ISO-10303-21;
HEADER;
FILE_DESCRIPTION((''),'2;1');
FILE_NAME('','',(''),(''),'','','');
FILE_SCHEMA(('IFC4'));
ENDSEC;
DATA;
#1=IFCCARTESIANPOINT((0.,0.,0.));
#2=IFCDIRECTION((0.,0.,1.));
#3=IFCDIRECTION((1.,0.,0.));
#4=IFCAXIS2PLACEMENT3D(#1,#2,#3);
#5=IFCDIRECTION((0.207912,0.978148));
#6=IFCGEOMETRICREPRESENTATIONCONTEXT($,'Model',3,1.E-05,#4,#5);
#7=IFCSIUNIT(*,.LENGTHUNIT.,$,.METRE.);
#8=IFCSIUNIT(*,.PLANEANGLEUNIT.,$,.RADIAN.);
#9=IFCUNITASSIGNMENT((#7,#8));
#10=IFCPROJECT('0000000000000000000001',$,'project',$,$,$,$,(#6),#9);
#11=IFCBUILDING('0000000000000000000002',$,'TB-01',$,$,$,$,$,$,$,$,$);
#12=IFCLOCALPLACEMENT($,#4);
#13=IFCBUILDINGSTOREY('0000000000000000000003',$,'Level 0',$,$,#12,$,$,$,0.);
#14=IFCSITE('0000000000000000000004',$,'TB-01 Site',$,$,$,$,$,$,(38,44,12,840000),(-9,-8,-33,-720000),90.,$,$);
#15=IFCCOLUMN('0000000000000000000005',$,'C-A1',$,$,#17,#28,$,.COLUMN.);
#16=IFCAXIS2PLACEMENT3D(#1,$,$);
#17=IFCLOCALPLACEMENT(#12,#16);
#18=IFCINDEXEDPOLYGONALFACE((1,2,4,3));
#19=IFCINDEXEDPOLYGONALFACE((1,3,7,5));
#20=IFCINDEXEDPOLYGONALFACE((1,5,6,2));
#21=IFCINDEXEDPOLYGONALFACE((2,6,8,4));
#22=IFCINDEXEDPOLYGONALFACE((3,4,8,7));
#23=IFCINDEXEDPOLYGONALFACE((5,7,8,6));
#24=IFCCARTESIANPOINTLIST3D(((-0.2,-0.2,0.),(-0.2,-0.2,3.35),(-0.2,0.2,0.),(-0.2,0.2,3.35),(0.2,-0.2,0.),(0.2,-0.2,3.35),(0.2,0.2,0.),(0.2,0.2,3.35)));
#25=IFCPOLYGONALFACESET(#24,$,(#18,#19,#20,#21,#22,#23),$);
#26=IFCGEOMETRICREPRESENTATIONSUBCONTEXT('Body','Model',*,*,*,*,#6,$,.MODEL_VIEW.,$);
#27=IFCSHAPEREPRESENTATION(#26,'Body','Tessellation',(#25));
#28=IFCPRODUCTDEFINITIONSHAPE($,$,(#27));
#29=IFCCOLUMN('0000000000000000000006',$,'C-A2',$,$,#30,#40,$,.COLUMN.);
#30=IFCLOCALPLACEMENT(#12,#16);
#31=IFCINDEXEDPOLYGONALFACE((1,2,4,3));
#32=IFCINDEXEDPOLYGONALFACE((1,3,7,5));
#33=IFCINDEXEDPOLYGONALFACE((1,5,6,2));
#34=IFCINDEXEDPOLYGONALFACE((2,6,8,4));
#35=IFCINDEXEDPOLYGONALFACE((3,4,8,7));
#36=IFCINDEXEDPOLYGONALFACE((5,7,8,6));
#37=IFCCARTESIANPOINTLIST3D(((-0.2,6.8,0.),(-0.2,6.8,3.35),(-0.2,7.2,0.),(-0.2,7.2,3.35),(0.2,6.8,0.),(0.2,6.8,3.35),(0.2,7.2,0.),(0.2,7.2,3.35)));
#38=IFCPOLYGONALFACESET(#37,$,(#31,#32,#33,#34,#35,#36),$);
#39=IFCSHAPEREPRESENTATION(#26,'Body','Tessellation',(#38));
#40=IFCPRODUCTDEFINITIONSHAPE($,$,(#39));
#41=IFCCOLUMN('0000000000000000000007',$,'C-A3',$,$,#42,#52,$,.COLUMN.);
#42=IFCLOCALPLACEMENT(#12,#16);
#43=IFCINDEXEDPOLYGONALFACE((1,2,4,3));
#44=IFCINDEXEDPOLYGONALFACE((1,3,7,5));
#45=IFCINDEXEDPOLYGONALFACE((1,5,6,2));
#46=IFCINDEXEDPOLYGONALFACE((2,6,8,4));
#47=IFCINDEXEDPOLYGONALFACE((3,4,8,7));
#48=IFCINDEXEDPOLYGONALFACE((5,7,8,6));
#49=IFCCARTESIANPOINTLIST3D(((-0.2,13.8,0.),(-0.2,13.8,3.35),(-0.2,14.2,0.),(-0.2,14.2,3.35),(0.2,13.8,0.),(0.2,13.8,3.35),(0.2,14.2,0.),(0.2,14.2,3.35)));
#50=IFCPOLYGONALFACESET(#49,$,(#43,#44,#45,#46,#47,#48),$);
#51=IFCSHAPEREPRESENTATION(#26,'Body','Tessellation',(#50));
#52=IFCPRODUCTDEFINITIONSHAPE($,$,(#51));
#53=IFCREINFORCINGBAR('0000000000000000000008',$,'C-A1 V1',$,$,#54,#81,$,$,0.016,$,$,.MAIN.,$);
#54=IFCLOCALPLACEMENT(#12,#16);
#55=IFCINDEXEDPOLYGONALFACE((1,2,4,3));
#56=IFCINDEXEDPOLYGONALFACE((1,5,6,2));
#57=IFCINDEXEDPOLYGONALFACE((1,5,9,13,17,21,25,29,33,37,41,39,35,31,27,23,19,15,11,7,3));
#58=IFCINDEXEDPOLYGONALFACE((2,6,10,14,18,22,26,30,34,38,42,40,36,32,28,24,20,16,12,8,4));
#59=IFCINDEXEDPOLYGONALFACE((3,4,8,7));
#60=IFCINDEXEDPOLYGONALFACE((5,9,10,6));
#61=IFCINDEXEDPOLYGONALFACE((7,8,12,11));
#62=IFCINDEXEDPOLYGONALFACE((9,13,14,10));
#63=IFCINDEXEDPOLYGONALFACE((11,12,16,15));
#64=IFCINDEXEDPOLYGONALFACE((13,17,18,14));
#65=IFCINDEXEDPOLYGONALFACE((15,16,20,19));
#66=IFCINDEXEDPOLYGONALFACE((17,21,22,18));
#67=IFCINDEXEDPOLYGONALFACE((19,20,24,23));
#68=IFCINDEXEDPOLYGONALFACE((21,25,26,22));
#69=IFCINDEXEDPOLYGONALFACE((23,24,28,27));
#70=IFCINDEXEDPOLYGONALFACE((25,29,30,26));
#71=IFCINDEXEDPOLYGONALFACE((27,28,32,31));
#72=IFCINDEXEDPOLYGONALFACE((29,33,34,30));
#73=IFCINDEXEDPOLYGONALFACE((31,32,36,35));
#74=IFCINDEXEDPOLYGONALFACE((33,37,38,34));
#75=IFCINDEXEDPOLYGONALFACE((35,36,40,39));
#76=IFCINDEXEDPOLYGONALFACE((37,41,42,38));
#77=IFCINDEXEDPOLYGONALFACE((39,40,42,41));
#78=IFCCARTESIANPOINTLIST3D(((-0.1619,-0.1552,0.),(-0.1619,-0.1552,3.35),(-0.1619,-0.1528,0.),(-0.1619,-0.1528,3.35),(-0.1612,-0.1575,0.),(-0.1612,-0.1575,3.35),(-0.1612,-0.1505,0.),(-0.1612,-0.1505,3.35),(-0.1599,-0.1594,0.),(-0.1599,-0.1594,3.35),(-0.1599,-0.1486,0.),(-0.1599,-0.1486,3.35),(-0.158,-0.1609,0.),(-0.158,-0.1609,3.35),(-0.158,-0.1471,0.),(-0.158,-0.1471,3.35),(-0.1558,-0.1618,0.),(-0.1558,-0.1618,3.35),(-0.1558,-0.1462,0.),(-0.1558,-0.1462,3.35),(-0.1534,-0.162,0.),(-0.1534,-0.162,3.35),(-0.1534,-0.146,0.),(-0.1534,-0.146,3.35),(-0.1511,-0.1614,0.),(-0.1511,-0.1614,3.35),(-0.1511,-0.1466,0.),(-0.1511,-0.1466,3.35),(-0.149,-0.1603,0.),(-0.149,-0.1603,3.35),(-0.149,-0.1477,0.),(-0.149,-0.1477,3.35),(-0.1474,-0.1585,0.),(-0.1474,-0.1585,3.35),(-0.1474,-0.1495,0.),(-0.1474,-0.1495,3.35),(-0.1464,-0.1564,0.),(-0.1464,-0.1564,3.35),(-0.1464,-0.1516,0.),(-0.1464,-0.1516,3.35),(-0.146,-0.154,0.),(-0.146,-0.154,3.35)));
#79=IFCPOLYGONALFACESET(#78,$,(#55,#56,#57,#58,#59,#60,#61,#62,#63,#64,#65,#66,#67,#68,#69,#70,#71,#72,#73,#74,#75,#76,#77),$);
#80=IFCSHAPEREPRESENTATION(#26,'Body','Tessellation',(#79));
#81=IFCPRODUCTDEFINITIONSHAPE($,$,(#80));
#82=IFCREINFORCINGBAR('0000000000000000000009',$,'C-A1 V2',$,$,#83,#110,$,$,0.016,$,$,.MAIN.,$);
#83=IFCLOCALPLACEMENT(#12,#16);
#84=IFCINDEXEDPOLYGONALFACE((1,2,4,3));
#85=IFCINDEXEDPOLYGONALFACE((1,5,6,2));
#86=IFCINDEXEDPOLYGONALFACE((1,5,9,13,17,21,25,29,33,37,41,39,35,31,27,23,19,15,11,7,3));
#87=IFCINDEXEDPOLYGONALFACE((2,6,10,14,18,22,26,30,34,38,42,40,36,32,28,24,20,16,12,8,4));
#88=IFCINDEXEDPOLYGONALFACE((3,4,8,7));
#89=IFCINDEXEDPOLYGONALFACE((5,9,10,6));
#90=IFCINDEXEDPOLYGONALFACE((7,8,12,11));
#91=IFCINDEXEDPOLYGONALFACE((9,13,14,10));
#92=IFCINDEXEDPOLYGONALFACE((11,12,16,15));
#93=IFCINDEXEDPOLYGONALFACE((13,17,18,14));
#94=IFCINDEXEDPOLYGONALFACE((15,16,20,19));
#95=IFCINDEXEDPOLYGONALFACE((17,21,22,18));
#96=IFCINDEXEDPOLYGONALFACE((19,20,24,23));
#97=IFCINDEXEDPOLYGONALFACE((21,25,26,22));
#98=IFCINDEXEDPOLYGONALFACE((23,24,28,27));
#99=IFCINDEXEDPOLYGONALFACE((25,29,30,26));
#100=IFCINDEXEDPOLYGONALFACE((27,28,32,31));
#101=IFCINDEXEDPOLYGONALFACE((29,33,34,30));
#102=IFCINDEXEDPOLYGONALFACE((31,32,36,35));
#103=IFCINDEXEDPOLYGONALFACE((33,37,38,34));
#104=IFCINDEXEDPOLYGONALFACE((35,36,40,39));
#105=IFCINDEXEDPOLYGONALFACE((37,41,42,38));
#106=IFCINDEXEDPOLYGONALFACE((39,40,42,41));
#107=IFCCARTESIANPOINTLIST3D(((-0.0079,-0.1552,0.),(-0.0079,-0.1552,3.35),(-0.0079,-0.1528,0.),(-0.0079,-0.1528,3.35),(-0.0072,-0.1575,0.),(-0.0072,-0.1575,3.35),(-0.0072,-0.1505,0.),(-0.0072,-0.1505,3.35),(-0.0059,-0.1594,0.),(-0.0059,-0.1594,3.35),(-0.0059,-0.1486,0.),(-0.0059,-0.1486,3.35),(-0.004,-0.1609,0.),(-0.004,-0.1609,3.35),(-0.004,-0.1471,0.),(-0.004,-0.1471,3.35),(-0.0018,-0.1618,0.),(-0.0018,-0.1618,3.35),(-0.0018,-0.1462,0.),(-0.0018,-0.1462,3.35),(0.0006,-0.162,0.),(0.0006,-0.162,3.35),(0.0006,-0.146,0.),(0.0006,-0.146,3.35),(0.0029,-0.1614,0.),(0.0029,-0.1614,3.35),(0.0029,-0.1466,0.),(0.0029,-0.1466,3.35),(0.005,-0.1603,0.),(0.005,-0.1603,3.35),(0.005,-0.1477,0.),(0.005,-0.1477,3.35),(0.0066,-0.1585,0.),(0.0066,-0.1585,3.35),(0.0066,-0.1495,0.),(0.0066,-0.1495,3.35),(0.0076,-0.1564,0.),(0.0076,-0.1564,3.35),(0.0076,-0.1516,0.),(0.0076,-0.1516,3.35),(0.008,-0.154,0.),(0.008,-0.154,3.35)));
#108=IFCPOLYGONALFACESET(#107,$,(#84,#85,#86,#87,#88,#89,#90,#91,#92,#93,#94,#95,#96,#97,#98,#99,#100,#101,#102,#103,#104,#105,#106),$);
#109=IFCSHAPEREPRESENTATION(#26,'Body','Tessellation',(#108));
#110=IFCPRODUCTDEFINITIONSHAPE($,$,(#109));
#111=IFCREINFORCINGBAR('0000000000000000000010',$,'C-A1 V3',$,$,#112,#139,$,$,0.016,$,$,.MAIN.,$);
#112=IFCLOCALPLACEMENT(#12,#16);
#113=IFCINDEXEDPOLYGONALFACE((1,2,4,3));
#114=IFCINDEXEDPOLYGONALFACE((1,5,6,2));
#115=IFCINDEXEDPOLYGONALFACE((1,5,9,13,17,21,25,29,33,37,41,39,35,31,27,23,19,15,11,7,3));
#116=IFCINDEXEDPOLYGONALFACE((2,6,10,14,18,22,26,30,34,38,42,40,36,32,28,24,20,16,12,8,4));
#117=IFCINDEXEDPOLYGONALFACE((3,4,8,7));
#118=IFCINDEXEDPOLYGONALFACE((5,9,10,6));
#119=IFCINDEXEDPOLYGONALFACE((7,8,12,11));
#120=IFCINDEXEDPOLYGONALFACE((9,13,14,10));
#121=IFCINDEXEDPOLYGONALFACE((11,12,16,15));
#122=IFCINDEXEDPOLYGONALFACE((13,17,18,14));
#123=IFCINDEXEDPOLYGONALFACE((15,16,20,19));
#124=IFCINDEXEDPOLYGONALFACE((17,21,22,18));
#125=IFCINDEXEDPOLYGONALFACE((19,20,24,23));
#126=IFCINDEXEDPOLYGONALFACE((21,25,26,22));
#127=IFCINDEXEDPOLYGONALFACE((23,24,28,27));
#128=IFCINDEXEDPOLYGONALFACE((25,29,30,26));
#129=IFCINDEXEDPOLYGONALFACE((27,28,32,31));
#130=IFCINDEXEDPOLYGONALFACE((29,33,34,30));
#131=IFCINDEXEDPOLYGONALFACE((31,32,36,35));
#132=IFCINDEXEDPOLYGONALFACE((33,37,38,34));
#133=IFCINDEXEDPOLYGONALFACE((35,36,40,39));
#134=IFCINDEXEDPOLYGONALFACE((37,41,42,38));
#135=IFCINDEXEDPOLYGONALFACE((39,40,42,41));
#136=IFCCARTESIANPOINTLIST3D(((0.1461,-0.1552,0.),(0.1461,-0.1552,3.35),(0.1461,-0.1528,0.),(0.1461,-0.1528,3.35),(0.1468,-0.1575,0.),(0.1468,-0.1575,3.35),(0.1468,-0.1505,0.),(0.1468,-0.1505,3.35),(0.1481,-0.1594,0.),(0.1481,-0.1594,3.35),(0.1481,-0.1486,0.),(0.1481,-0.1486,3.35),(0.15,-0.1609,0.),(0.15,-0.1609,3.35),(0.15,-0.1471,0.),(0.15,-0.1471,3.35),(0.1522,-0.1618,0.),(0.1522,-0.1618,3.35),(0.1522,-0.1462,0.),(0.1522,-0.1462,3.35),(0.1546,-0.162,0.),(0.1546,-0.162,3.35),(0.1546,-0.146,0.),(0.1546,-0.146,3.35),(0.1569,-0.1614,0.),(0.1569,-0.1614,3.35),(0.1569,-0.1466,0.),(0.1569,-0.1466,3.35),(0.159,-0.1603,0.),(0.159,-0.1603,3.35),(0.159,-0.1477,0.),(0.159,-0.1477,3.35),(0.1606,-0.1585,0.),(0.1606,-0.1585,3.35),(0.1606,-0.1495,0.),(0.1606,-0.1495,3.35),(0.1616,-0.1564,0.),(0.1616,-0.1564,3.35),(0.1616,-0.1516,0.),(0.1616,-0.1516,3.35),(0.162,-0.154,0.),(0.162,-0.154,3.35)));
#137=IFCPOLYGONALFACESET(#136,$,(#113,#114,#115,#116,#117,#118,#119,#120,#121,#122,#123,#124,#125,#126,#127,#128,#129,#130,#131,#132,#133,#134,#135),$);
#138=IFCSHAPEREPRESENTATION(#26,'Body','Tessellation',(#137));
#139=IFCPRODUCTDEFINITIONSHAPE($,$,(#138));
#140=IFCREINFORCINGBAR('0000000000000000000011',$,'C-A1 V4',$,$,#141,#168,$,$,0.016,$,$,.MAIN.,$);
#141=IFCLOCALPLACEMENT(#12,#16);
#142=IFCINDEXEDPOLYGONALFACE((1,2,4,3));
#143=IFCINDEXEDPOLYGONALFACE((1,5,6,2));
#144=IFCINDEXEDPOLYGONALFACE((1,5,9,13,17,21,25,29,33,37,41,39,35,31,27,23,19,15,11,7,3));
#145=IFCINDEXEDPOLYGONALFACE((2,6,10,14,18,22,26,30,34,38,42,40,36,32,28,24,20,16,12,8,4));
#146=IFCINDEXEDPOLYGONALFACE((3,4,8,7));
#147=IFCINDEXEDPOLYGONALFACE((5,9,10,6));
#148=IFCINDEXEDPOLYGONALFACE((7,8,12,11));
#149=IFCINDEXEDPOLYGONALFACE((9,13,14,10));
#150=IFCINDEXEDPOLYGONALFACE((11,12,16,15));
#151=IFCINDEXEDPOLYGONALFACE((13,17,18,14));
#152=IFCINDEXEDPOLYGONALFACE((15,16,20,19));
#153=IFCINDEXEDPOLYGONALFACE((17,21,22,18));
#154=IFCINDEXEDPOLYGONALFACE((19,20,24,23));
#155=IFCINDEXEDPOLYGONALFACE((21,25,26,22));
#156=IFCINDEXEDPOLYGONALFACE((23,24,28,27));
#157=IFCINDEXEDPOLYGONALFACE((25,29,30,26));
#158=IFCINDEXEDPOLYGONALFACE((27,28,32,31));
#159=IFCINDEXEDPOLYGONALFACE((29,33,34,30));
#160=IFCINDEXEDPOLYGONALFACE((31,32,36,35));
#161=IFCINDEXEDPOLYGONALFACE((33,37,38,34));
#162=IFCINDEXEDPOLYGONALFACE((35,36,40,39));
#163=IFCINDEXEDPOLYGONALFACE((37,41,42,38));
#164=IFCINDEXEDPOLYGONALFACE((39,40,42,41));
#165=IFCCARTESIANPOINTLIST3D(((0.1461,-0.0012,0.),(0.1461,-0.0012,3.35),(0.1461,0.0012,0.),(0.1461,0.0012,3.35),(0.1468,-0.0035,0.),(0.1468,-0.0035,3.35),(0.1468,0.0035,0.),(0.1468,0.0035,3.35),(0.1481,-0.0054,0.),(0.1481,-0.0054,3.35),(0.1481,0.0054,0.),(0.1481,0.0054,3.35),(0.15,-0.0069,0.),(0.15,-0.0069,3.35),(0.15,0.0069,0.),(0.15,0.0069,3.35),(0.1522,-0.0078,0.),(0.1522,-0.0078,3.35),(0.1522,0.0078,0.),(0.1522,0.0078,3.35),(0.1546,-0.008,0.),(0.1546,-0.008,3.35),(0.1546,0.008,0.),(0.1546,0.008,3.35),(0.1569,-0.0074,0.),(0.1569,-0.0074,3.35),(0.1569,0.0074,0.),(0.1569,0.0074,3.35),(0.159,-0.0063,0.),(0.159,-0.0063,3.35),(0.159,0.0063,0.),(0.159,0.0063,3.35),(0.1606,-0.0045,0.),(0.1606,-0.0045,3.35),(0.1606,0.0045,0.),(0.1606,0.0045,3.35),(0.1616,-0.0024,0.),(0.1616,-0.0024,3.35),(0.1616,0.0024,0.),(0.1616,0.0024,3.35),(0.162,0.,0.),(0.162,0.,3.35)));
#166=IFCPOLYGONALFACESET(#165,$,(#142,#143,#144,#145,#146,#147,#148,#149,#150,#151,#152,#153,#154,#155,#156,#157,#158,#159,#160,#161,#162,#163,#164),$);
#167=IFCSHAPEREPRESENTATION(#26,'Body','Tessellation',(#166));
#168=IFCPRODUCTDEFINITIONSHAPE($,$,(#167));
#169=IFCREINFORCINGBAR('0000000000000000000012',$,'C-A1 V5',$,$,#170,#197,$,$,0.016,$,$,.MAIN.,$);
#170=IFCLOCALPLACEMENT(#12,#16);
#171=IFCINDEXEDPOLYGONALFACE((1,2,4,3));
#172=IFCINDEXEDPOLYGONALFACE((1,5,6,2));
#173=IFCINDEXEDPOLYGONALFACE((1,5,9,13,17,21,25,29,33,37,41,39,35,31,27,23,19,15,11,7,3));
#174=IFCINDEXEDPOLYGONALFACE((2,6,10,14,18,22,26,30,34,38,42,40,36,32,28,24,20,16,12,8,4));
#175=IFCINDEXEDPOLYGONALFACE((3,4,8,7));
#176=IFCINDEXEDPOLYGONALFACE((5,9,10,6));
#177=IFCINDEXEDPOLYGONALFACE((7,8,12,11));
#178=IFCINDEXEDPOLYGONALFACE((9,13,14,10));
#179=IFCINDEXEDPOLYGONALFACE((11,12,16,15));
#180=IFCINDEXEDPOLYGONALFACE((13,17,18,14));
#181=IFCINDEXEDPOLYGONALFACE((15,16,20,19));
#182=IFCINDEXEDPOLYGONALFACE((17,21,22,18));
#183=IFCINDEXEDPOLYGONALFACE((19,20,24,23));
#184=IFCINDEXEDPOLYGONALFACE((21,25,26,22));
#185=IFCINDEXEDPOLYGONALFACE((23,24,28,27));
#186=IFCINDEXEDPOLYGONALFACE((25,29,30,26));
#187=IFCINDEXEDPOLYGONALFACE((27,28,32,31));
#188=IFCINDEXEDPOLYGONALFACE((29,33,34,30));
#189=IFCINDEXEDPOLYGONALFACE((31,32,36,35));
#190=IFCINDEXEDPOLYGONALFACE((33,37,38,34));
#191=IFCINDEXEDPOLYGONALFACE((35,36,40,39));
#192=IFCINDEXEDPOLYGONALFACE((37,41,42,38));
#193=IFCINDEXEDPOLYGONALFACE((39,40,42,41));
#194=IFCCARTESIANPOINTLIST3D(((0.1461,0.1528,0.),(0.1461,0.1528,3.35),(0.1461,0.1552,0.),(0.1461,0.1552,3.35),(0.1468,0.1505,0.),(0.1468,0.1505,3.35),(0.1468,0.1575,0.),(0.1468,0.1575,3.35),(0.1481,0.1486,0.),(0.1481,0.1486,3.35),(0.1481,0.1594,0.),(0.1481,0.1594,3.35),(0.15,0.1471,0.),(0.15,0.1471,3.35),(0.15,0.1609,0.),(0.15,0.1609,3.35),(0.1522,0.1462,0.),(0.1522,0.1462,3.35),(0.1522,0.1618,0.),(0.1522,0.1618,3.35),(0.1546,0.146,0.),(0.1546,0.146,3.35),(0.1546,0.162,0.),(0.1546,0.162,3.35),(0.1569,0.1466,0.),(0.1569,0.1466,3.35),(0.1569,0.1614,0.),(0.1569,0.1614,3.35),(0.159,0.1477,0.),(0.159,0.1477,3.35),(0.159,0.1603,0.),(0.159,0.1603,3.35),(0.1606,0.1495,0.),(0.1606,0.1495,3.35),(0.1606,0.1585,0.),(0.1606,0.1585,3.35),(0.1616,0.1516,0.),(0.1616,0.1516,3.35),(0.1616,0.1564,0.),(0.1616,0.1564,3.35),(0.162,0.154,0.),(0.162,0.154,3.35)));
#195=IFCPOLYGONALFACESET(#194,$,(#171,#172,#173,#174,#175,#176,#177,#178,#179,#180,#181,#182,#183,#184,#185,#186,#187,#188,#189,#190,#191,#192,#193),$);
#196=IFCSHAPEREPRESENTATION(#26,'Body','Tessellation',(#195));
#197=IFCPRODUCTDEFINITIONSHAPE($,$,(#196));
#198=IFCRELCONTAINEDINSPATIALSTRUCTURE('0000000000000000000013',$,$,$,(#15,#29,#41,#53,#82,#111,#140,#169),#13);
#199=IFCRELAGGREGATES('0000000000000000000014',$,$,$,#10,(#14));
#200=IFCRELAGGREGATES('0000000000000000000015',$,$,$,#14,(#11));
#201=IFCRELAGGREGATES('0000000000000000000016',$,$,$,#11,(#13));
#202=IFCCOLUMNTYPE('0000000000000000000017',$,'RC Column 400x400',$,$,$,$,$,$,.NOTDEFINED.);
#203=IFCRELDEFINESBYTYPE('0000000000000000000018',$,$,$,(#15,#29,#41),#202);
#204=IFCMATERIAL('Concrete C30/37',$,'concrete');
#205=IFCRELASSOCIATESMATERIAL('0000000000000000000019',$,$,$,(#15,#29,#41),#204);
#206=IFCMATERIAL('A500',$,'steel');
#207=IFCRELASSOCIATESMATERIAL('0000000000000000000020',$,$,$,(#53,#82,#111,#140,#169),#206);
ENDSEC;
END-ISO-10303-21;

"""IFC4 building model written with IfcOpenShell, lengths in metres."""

from ifc_helpers import new_model, entity, si_unit, direction, frame, origin_with_axes, place, context, subcontext, project, spatial, rectangle, extrude, material, type_object, element, save


model = new_model("IFC4")

# Units and contexts
model_context = context("Model", 3, precision=1e-05, world=origin_with_axes(), true_north=direction((0.207912, 0.978148)))
body_context = subcontext(model_context, "Body", "Model", "MODEL_VIEW")
ifc_project = project(units=[si_unit("LENGTHUNIT", "METRE"), si_unit("PLANEANGLEUNIT", "RADIAN")], contexts=[model_context])

# Site, building, storey
site = spatial("IfcSite", under=ifc_project, Name="TB-01 Site", RefLatitude=(38, 44, 12, 840000), RefLongitude=(-9, -8, -33, -720000), RefElevation=90.0)
building = spatial("IfcBuilding", under=site, Name="TB-01")
storey_placement = place(None, origin_with_axes())
storey = spatial("IfcBuildingStorey", under=building, at=storey_placement, Name="Level 0", Elevation=0.0)

# Columns
ifc_material_1 = material(Name="Concrete C30/37", Category="concrete")
column_type = type_object("IfcColumnType", Name="RC Column 400x400", PredefinedType="NOTDEFINED")
column_1_placement = place(storey_placement, origin_with_axes())
element("IfcColumn", 1, at=column_1_placement, inside=storey, type_object=column_type, material=ifc_material_1, Name="C-A1", PredefinedType="COLUMN", context=body_context, shape_type="SweptSolid", body=[
    extrude(rectangle(XDim=0.4, YDim=0.4), origin_with_axes(), (0.0, 0.0, 1.0), 3.35),
])
column_2_placement = place(storey_placement, frame((0.0, 7.0, 0.0), z_axis=(0.0, 0.0, 1.0), x_axis=(1.0, 0.0, 0.0)))
element("IfcColumn", 2, at=column_2_placement, inside=storey, type_object=column_type, material=ifc_material_1, Name="C-A2", PredefinedType="COLUMN", context=body_context, shape_type="SweptSolid", body=[
    extrude(rectangle(XDim=0.4, YDim=0.4), origin_with_axes(), (0.0, 0.0, 1.0), 3.35),
])
column_3_placement = place(storey_placement, frame((0.0, 14.0, 0.0), z_axis=(0.0, 0.0, 1.0), x_axis=(1.0, 0.0, 0.0)))
element("IfcColumn", 3, at=column_3_placement, inside=storey, type_object=column_type, material=ifc_material_1, Name="C-A3", PredefinedType="COLUMN", context=body_context, shape_type="SweptSolid", body=[
    extrude(rectangle(XDim=0.4, YDim=0.4), origin_with_axes(), (0.0, 0.0, 1.0), 3.35),
])

# Reinforcing bars
ifc_material_2 = material(Name="A500", Category="steel")
reinforcing_bar_1_placement = place(storey_placement, origin_with_axes())
element("IfcReinforcingBar", 4, at=reinforcing_bar_1_placement, inside=storey, material=ifc_material_2, Name="C-A1 V1", NominalDiameter=0.016, PredefinedType="MAIN", context=body_context, shape_type="AdvancedSweptSolid", body=[
    entity("IfcSweptDiskSolid", entity("IfcPolyline", [entity("IfcCartesianPoint", [-0.154, -0.154, 0.0]), entity("IfcCartesianPoint", [-0.154, -0.154, 3.35])]), 0.008),
])
reinforcing_bar_2_placement = place(storey_placement, origin_with_axes())
element("IfcReinforcingBar", 5, at=reinforcing_bar_2_placement, inside=storey, material=ifc_material_2, Name="C-A1 V2", NominalDiameter=0.016, PredefinedType="MAIN", context=body_context, shape_type="AdvancedSweptSolid", body=[
    entity("IfcSweptDiskSolid", entity("IfcPolyline", [entity("IfcCartesianPoint", [0.0, -0.154, 0.0]), entity("IfcCartesianPoint", [0.0, -0.154, 3.35])]), 0.008),
])
reinforcing_bar_3_placement = place(storey_placement, origin_with_axes())
element("IfcReinforcingBar", 6, at=reinforcing_bar_3_placement, inside=storey, material=ifc_material_2, Name="C-A1 V3", NominalDiameter=0.016, PredefinedType="MAIN", context=body_context, shape_type="AdvancedSweptSolid", body=[
    entity("IfcSweptDiskSolid", entity("IfcPolyline", [entity("IfcCartesianPoint", [0.154, -0.154, 0.0]), entity("IfcCartesianPoint", [0.154, -0.154, 3.35])]), 0.008),
])
reinforcing_bar_4_placement = place(storey_placement, origin_with_axes())
element("IfcReinforcingBar", 7, at=reinforcing_bar_4_placement, inside=storey, material=ifc_material_2, Name="C-A1 V4", NominalDiameter=0.016, PredefinedType="MAIN", context=body_context, shape_type="AdvancedSweptSolid", body=[
    entity("IfcSweptDiskSolid", entity("IfcPolyline", [entity("IfcCartesianPoint", [0.154, 0.0, 0.0]), entity("IfcCartesianPoint", [0.154, 0.0, 3.35])]), 0.008),
])
reinforcing_bar_5_placement = place(storey_placement, origin_with_axes())
element("IfcReinforcingBar", 8, at=reinforcing_bar_5_placement, inside=storey, material=ifc_material_2, Name="C-A1 V5", NominalDiameter=0.016, PredefinedType="MAIN", context=body_context, shape_type="AdvancedSweptSolid", body=[
    entity("IfcSweptDiskSolid", entity("IfcPolyline", [entity("IfcCartesianPoint", [0.154, 0.154, 0.0]), entity("IfcCartesianPoint", [0.154, 0.154, 3.35])]), 0.008),
])

save(model, "model.ifc")
